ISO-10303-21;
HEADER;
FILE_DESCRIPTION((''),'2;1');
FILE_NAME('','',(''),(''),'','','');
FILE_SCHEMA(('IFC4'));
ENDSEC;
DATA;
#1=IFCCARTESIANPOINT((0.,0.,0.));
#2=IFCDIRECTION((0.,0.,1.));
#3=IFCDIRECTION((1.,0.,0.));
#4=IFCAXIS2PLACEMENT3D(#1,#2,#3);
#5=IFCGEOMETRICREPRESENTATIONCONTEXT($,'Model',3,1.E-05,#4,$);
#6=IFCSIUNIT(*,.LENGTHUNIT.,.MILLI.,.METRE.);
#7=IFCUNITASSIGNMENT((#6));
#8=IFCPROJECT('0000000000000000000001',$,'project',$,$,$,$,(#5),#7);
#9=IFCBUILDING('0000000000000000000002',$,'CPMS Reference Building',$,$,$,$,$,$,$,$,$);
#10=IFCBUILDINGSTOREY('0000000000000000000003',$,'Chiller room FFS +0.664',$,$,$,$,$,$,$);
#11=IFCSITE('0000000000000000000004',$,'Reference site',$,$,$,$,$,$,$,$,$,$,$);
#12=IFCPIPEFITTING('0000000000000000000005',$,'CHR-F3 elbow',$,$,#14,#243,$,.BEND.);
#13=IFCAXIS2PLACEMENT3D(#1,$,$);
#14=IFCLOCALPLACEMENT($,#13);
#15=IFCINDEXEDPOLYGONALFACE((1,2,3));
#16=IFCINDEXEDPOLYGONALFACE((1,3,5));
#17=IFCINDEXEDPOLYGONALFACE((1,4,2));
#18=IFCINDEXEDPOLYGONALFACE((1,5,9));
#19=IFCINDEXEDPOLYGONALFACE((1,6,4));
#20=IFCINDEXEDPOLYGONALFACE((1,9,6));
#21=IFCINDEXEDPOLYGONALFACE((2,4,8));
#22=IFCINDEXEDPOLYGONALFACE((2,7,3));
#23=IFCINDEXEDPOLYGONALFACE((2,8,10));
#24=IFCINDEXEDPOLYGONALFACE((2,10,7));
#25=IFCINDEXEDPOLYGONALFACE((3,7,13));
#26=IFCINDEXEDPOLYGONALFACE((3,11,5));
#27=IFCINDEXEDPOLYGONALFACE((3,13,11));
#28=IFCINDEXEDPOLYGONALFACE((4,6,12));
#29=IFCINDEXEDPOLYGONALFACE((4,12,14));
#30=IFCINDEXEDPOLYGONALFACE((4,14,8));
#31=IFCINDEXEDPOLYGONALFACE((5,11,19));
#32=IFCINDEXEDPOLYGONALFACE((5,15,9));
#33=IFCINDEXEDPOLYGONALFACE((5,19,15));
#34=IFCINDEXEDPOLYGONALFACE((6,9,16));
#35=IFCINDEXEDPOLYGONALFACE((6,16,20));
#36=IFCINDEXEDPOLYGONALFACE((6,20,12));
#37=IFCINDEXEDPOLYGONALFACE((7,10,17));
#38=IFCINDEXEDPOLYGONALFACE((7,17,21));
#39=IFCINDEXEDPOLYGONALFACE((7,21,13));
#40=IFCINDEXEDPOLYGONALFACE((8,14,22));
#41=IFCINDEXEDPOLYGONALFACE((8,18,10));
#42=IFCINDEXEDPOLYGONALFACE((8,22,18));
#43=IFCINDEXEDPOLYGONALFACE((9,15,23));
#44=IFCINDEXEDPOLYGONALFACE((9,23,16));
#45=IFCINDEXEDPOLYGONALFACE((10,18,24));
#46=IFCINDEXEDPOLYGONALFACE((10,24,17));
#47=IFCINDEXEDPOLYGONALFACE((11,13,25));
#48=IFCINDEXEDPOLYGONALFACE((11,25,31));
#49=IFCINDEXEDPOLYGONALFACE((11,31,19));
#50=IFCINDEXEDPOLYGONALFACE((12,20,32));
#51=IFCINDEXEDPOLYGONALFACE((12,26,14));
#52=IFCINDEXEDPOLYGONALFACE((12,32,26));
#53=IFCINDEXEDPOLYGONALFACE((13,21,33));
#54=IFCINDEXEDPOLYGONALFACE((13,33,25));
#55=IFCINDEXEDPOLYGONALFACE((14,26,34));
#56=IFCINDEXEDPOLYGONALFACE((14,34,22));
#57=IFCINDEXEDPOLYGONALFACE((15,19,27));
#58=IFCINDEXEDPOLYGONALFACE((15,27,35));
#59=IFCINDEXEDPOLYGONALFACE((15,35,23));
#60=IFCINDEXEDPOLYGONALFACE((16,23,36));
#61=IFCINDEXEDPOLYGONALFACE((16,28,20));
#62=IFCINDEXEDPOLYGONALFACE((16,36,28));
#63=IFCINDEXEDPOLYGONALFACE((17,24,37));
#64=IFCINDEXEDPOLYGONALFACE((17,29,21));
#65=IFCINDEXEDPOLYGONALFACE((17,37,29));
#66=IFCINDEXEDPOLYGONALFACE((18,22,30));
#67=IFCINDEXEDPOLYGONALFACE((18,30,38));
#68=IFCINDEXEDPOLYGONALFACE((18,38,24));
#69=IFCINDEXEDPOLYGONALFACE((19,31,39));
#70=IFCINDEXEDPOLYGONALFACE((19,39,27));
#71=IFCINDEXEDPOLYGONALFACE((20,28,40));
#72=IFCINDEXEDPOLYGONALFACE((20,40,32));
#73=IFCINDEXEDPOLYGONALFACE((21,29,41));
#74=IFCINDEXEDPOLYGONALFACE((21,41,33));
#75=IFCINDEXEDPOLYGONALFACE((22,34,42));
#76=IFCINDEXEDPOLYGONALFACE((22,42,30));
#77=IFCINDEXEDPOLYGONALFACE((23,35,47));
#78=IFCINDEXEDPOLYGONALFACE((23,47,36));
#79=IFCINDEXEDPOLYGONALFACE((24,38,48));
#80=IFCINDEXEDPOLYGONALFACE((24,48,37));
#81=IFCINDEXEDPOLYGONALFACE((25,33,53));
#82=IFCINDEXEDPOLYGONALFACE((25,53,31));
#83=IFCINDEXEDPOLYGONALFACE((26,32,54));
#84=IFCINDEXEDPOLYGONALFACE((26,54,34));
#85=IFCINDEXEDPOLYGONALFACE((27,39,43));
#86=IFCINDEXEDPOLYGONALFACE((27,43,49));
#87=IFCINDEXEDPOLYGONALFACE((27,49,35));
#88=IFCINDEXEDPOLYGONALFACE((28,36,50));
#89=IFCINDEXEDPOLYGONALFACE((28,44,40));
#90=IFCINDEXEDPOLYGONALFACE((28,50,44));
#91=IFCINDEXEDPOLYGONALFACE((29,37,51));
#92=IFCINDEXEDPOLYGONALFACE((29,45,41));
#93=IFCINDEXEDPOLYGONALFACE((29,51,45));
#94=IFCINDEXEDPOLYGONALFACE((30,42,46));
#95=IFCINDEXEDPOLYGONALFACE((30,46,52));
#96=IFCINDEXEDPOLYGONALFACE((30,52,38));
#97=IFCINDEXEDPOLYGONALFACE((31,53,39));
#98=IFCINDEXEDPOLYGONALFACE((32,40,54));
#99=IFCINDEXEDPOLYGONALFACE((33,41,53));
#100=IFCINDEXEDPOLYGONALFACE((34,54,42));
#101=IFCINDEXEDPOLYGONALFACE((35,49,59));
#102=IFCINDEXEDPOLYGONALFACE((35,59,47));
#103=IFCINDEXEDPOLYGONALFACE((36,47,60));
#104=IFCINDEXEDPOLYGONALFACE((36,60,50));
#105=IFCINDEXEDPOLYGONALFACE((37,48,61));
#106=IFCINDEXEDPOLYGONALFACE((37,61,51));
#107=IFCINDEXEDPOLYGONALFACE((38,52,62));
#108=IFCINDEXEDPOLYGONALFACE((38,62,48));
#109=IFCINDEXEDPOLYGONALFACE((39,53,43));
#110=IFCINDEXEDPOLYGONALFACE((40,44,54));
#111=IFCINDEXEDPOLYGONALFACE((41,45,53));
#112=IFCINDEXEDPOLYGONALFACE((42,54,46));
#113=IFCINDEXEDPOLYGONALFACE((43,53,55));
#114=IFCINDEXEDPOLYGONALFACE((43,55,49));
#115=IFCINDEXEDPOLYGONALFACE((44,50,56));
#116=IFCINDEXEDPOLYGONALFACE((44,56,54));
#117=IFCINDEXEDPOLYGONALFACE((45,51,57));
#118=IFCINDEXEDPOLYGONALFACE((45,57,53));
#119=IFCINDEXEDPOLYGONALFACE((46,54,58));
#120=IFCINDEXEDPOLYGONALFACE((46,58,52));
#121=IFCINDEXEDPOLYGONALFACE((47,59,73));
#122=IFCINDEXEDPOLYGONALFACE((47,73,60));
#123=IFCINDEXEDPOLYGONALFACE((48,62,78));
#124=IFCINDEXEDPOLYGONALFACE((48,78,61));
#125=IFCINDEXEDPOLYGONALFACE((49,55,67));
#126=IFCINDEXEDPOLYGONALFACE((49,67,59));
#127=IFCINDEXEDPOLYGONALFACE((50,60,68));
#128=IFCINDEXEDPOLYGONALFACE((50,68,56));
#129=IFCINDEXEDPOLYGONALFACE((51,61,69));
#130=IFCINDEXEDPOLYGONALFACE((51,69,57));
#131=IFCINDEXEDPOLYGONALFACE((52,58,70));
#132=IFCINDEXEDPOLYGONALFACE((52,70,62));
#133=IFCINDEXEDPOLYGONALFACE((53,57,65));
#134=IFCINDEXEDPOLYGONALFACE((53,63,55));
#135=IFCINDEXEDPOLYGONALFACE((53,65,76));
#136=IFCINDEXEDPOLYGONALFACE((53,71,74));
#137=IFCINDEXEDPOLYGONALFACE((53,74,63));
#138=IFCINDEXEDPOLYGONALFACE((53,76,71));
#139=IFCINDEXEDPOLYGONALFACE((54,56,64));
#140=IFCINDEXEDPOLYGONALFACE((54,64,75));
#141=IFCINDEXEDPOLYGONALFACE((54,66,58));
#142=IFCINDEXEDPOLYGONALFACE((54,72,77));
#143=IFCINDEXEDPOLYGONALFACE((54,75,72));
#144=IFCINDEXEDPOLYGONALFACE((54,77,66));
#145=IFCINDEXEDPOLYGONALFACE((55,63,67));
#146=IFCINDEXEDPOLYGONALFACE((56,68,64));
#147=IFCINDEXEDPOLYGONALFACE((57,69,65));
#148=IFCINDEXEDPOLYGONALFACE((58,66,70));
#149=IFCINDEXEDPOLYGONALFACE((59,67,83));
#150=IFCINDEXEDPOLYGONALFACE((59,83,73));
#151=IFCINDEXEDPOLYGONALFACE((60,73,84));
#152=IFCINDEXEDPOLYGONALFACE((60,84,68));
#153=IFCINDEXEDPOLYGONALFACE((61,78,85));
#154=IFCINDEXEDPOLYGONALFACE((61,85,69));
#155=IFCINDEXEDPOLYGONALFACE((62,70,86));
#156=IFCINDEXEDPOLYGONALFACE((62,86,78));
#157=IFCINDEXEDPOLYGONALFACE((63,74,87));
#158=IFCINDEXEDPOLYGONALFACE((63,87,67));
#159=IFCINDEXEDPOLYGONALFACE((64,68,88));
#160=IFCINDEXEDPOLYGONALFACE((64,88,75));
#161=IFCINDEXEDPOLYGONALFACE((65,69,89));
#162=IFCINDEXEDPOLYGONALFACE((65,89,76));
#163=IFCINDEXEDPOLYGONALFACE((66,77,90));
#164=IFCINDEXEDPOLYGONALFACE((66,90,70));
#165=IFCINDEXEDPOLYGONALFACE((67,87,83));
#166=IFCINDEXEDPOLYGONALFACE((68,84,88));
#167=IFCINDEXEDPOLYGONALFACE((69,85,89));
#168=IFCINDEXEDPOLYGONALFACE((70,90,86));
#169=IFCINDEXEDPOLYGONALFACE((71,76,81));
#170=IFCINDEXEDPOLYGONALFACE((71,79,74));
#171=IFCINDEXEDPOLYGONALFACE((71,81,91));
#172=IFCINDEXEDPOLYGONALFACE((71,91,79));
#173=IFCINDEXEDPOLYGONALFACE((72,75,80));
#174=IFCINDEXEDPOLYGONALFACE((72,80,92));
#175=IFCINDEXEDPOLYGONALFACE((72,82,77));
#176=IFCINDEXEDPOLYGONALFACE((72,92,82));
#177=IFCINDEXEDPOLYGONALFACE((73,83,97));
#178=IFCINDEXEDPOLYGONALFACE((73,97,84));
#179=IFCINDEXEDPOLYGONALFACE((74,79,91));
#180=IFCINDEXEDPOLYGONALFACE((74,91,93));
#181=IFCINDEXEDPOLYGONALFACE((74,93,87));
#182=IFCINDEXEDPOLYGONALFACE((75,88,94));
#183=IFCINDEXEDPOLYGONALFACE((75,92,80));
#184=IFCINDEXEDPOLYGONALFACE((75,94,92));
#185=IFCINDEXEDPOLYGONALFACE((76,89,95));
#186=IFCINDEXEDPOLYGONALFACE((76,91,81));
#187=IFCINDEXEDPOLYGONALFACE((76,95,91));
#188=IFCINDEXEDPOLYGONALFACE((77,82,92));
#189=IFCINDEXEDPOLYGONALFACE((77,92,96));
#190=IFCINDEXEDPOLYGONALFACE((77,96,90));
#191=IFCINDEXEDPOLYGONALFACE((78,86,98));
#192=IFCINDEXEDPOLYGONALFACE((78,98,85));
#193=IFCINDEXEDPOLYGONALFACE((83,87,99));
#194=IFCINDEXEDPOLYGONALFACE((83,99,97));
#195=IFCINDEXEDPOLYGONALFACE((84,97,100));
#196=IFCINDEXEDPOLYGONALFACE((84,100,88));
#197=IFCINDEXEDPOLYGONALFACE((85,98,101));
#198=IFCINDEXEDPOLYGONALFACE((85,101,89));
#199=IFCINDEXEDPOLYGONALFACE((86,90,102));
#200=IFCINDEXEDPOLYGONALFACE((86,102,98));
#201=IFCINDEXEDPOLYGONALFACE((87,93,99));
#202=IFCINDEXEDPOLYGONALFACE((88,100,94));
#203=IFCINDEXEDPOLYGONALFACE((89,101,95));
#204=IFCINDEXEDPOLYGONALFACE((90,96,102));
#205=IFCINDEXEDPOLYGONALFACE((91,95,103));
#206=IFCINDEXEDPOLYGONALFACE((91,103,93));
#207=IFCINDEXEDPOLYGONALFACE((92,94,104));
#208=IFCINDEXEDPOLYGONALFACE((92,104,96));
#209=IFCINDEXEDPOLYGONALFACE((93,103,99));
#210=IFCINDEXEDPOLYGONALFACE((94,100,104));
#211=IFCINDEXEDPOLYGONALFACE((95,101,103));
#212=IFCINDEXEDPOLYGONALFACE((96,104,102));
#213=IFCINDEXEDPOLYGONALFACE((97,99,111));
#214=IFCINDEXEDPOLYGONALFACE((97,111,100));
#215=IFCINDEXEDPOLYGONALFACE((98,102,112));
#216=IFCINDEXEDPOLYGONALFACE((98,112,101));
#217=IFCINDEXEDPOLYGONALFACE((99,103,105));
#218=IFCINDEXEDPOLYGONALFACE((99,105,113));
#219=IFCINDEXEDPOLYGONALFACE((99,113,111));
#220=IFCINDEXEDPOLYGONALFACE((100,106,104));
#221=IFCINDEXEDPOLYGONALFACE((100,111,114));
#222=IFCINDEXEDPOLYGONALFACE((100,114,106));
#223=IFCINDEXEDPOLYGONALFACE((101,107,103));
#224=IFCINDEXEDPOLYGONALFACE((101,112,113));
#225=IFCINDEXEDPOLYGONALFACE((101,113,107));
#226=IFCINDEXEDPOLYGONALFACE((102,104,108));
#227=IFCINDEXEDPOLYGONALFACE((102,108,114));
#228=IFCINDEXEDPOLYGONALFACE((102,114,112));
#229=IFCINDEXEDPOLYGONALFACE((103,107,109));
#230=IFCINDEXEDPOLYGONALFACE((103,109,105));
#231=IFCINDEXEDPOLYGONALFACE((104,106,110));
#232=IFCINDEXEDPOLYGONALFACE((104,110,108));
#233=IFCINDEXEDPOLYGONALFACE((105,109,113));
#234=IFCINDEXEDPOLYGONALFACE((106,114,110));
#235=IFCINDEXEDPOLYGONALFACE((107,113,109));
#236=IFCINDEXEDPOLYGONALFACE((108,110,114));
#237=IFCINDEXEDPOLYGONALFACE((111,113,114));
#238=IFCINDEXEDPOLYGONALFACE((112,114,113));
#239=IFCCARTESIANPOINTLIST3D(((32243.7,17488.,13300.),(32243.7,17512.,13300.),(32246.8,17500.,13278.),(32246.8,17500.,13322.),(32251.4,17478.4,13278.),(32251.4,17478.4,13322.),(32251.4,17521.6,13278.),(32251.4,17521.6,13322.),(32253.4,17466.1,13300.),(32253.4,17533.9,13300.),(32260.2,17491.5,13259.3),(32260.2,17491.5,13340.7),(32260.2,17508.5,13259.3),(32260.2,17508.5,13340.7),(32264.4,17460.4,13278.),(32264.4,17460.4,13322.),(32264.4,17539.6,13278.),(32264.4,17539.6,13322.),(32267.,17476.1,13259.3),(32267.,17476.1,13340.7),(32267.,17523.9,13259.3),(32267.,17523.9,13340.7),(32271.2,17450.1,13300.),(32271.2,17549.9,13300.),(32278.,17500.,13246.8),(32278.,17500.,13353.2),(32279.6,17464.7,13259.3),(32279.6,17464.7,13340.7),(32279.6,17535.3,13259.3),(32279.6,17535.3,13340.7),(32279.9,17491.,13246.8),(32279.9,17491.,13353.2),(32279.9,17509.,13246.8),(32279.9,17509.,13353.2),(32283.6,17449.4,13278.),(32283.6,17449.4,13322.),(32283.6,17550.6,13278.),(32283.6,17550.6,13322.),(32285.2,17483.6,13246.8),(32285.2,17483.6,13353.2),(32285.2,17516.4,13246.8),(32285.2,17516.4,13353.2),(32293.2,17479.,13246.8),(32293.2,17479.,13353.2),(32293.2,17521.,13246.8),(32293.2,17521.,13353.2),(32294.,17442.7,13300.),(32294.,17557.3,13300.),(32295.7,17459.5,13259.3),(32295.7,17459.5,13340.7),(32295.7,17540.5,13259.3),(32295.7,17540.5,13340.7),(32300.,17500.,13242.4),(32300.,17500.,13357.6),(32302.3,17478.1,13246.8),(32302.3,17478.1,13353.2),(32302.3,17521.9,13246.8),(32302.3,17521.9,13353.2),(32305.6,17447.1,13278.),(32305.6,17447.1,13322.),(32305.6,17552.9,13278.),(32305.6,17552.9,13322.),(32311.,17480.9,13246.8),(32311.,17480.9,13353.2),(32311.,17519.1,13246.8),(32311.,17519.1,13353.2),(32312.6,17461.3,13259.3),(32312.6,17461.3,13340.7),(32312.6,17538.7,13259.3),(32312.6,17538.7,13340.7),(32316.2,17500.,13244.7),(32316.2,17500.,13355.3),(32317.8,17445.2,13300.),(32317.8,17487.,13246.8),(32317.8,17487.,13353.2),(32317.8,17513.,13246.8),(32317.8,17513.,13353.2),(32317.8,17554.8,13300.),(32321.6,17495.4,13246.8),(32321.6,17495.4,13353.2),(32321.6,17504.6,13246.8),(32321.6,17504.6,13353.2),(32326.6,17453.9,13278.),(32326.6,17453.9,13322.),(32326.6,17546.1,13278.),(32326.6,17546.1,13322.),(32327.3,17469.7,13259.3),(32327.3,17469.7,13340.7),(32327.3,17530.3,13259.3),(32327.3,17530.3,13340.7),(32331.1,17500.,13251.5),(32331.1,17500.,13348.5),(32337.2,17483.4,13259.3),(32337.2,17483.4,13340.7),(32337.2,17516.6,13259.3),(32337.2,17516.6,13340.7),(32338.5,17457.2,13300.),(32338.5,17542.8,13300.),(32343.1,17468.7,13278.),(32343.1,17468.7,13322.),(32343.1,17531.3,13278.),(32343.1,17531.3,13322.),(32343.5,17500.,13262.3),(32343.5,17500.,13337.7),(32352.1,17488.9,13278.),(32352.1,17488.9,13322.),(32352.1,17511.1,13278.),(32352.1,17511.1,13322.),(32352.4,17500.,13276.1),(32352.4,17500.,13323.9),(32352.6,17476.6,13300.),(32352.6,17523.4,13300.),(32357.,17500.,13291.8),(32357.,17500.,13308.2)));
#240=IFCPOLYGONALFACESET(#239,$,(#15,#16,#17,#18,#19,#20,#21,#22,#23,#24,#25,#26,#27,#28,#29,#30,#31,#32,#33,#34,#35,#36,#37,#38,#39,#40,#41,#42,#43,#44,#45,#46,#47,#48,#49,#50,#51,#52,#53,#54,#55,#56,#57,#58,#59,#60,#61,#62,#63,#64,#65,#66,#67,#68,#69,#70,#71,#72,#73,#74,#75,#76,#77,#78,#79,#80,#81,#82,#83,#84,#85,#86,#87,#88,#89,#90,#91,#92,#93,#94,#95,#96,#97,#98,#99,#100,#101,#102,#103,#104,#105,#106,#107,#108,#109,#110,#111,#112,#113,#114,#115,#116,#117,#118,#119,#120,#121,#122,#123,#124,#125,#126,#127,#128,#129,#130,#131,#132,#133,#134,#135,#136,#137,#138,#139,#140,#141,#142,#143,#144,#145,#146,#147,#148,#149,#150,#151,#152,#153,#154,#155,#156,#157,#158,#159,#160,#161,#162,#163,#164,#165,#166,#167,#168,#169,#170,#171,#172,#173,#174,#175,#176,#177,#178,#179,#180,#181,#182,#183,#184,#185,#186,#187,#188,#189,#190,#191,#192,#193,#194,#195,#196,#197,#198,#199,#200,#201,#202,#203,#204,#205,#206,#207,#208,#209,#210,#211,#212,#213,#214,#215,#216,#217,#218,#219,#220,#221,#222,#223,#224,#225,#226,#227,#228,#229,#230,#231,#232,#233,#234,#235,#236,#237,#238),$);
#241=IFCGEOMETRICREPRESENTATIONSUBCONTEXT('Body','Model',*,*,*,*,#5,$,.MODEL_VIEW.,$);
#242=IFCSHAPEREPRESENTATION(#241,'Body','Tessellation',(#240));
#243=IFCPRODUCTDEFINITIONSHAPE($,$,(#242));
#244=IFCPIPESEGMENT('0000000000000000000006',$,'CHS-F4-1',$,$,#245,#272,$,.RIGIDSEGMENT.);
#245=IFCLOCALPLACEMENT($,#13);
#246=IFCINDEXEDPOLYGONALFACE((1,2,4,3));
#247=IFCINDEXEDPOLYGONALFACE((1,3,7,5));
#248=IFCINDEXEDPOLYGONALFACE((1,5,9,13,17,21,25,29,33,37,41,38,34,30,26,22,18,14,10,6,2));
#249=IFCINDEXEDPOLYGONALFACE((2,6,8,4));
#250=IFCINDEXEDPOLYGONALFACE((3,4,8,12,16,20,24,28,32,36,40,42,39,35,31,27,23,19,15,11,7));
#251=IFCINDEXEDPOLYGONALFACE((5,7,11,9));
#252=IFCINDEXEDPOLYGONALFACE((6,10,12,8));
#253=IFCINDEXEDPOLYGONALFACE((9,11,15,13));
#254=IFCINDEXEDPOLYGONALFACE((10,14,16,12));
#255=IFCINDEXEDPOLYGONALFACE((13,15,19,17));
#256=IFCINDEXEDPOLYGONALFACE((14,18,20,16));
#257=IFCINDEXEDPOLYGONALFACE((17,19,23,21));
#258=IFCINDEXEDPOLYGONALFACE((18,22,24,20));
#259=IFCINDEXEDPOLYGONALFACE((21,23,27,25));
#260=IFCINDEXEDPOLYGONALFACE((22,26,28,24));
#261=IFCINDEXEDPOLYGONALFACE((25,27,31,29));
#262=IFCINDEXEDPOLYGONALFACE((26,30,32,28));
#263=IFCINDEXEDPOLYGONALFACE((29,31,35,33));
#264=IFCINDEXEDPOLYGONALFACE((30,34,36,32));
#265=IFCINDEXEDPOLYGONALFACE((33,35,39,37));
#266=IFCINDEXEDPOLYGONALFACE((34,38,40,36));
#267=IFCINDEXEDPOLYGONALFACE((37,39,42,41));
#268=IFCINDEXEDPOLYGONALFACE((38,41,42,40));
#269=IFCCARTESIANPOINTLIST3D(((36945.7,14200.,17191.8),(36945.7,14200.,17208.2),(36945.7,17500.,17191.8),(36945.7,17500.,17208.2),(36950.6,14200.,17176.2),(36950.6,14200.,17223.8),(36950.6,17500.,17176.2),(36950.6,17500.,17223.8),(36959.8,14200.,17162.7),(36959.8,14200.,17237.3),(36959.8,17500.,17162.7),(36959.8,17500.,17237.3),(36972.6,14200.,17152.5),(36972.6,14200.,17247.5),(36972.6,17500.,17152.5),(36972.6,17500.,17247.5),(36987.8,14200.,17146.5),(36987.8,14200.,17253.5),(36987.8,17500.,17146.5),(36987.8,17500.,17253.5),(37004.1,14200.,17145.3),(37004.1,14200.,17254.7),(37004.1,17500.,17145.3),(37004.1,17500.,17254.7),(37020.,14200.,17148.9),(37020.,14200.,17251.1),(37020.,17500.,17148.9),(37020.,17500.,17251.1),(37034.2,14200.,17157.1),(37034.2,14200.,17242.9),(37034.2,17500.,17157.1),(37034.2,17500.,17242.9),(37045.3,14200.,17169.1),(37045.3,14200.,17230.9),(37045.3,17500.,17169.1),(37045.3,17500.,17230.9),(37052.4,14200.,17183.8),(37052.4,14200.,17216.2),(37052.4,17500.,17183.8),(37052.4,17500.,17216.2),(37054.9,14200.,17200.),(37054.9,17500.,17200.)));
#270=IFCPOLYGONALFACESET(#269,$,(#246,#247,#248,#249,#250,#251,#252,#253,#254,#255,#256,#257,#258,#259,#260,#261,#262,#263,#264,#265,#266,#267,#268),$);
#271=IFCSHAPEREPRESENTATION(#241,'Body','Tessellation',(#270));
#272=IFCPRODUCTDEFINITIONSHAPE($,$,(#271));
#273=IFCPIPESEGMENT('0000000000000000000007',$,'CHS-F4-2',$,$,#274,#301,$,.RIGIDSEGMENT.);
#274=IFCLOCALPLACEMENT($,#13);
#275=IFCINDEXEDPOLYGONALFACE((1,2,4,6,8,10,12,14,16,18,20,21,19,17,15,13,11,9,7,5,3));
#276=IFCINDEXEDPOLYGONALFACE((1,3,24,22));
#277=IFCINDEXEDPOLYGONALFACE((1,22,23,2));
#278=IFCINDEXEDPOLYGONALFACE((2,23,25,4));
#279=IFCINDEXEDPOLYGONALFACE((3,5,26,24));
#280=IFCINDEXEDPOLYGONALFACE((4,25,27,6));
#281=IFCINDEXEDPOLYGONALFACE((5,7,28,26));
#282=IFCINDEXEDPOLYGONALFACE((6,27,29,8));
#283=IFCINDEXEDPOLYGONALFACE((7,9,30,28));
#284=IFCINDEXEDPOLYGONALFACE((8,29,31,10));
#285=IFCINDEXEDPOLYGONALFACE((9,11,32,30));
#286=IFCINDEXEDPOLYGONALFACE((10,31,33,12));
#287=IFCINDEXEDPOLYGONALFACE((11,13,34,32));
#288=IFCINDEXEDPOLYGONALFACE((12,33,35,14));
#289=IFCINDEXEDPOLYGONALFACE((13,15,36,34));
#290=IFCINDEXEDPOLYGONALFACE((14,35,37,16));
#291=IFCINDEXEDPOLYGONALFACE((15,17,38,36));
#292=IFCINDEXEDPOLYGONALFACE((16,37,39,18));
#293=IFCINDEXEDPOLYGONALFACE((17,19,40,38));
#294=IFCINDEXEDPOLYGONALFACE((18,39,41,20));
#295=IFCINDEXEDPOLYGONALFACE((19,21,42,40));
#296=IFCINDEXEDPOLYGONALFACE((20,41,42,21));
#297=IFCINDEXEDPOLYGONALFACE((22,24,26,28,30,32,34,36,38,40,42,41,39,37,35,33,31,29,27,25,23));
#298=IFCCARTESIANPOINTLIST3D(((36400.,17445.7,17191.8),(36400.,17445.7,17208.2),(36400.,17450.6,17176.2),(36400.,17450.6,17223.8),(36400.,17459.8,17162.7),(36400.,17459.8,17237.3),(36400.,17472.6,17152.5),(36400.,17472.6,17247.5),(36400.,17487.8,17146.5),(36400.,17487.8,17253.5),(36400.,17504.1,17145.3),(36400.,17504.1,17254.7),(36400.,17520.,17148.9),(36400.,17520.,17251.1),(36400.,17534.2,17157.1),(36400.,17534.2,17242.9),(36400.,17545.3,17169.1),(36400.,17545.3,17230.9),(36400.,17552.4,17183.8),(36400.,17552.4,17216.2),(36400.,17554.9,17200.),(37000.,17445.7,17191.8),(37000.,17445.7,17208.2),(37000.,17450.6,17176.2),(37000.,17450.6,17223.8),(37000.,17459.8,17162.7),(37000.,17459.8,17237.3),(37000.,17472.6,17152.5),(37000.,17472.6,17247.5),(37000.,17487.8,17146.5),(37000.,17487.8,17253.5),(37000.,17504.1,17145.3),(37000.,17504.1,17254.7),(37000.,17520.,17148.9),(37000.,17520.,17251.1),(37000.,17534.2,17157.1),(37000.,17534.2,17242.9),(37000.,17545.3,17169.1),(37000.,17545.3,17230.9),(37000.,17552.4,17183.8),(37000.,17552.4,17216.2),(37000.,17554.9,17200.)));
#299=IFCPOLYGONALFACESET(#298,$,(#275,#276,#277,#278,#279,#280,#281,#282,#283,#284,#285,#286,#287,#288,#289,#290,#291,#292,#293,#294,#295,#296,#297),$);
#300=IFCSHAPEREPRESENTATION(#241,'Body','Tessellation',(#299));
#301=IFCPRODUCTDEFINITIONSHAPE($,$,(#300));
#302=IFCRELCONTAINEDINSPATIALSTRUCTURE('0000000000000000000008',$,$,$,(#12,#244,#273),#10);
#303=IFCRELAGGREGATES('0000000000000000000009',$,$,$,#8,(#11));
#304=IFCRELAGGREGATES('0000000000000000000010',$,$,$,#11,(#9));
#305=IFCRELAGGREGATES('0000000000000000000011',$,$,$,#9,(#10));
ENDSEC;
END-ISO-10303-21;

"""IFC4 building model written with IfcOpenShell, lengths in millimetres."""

from ifc_helpers import new_model, entity, si_unit, frame, origin_with_axes, origin_2d, place, context, subcontext, project, spatial, circle_curve, outline, extrude, element, save


model = new_model("IFC4")

# Units and contexts
model_context = context("Model", 3, precision=1e-05, world=origin_with_axes())
body_context = subcontext(model_context, "Body", "Model", "MODEL_VIEW")
ifc_project = project(units=[si_unit("LENGTHUNIT", "METRE", prefix="MILLI")], contexts=[model_context])

# Site, building, storey
site = spatial("IfcSite", under=ifc_project, Name="Reference site")
building = spatial("IfcBuilding", under=site, Name="CPMS Reference Building")
storey = spatial("IfcBuildingStorey", under=building, Name="Chiller room FFS +0.664")

# Pipe fitting
pipe_fitting_1_placement = place(None, origin_with_axes())
element("IfcPipeFitting", 1, at=pipe_fitting_1_placement, inside=storey, Name="CHR-F3 elbow", PredefinedType="BEND", context=body_context, shape_type="CSG", body=[
    entity("IfcSphere", entity("IfcAxis2Placement3D", entity("IfcCartesianPoint", [32300.0, 17500.0, 13300.0]), entity("IfcDirection", [0.0, 0.0, 1.0]), entity("IfcDirection", [1.0, 0.0, 0.0])), 57.6),
])

# Pipe segments
pipe_segment_1_placement = place(None, origin_with_axes())
element("IfcPipeSegment", 2, at=pipe_segment_1_placement, inside=storey, Name="CHS-F4-1", PredefinedType="RIGIDSEGMENT", context=body_context, shape_type="SweptSolid", body=[
    extrude(outline(circle_curve(origin_2d(), 54.9)), frame((37000.0, 14200.0, 17200.0), z_axis=(0.0, 1.0, 0.0), x_axis=(1.0, 0.0, 0.0)), (0.0, 0.0, 1.0), 3300.0),
])
pipe_segment_2_placement = place(None, origin_with_axes())
element("IfcPipeSegment", 3, at=pipe_segment_2_placement, inside=storey, Name="CHS-F4-2", PredefinedType="RIGIDSEGMENT", context=body_context, shape_type="SweptSolid", body=[
    extrude(outline(circle_curve(origin_2d(), 54.9)), frame((37000.0, 17500.0, 17200.0), z_axis=(-1.0, 0.0, 0.0), x_axis=(0.0, 1.0, 0.0)), (0.0, 0.0, 1.0), 600.0),
])

save(model, "model.ifc")
